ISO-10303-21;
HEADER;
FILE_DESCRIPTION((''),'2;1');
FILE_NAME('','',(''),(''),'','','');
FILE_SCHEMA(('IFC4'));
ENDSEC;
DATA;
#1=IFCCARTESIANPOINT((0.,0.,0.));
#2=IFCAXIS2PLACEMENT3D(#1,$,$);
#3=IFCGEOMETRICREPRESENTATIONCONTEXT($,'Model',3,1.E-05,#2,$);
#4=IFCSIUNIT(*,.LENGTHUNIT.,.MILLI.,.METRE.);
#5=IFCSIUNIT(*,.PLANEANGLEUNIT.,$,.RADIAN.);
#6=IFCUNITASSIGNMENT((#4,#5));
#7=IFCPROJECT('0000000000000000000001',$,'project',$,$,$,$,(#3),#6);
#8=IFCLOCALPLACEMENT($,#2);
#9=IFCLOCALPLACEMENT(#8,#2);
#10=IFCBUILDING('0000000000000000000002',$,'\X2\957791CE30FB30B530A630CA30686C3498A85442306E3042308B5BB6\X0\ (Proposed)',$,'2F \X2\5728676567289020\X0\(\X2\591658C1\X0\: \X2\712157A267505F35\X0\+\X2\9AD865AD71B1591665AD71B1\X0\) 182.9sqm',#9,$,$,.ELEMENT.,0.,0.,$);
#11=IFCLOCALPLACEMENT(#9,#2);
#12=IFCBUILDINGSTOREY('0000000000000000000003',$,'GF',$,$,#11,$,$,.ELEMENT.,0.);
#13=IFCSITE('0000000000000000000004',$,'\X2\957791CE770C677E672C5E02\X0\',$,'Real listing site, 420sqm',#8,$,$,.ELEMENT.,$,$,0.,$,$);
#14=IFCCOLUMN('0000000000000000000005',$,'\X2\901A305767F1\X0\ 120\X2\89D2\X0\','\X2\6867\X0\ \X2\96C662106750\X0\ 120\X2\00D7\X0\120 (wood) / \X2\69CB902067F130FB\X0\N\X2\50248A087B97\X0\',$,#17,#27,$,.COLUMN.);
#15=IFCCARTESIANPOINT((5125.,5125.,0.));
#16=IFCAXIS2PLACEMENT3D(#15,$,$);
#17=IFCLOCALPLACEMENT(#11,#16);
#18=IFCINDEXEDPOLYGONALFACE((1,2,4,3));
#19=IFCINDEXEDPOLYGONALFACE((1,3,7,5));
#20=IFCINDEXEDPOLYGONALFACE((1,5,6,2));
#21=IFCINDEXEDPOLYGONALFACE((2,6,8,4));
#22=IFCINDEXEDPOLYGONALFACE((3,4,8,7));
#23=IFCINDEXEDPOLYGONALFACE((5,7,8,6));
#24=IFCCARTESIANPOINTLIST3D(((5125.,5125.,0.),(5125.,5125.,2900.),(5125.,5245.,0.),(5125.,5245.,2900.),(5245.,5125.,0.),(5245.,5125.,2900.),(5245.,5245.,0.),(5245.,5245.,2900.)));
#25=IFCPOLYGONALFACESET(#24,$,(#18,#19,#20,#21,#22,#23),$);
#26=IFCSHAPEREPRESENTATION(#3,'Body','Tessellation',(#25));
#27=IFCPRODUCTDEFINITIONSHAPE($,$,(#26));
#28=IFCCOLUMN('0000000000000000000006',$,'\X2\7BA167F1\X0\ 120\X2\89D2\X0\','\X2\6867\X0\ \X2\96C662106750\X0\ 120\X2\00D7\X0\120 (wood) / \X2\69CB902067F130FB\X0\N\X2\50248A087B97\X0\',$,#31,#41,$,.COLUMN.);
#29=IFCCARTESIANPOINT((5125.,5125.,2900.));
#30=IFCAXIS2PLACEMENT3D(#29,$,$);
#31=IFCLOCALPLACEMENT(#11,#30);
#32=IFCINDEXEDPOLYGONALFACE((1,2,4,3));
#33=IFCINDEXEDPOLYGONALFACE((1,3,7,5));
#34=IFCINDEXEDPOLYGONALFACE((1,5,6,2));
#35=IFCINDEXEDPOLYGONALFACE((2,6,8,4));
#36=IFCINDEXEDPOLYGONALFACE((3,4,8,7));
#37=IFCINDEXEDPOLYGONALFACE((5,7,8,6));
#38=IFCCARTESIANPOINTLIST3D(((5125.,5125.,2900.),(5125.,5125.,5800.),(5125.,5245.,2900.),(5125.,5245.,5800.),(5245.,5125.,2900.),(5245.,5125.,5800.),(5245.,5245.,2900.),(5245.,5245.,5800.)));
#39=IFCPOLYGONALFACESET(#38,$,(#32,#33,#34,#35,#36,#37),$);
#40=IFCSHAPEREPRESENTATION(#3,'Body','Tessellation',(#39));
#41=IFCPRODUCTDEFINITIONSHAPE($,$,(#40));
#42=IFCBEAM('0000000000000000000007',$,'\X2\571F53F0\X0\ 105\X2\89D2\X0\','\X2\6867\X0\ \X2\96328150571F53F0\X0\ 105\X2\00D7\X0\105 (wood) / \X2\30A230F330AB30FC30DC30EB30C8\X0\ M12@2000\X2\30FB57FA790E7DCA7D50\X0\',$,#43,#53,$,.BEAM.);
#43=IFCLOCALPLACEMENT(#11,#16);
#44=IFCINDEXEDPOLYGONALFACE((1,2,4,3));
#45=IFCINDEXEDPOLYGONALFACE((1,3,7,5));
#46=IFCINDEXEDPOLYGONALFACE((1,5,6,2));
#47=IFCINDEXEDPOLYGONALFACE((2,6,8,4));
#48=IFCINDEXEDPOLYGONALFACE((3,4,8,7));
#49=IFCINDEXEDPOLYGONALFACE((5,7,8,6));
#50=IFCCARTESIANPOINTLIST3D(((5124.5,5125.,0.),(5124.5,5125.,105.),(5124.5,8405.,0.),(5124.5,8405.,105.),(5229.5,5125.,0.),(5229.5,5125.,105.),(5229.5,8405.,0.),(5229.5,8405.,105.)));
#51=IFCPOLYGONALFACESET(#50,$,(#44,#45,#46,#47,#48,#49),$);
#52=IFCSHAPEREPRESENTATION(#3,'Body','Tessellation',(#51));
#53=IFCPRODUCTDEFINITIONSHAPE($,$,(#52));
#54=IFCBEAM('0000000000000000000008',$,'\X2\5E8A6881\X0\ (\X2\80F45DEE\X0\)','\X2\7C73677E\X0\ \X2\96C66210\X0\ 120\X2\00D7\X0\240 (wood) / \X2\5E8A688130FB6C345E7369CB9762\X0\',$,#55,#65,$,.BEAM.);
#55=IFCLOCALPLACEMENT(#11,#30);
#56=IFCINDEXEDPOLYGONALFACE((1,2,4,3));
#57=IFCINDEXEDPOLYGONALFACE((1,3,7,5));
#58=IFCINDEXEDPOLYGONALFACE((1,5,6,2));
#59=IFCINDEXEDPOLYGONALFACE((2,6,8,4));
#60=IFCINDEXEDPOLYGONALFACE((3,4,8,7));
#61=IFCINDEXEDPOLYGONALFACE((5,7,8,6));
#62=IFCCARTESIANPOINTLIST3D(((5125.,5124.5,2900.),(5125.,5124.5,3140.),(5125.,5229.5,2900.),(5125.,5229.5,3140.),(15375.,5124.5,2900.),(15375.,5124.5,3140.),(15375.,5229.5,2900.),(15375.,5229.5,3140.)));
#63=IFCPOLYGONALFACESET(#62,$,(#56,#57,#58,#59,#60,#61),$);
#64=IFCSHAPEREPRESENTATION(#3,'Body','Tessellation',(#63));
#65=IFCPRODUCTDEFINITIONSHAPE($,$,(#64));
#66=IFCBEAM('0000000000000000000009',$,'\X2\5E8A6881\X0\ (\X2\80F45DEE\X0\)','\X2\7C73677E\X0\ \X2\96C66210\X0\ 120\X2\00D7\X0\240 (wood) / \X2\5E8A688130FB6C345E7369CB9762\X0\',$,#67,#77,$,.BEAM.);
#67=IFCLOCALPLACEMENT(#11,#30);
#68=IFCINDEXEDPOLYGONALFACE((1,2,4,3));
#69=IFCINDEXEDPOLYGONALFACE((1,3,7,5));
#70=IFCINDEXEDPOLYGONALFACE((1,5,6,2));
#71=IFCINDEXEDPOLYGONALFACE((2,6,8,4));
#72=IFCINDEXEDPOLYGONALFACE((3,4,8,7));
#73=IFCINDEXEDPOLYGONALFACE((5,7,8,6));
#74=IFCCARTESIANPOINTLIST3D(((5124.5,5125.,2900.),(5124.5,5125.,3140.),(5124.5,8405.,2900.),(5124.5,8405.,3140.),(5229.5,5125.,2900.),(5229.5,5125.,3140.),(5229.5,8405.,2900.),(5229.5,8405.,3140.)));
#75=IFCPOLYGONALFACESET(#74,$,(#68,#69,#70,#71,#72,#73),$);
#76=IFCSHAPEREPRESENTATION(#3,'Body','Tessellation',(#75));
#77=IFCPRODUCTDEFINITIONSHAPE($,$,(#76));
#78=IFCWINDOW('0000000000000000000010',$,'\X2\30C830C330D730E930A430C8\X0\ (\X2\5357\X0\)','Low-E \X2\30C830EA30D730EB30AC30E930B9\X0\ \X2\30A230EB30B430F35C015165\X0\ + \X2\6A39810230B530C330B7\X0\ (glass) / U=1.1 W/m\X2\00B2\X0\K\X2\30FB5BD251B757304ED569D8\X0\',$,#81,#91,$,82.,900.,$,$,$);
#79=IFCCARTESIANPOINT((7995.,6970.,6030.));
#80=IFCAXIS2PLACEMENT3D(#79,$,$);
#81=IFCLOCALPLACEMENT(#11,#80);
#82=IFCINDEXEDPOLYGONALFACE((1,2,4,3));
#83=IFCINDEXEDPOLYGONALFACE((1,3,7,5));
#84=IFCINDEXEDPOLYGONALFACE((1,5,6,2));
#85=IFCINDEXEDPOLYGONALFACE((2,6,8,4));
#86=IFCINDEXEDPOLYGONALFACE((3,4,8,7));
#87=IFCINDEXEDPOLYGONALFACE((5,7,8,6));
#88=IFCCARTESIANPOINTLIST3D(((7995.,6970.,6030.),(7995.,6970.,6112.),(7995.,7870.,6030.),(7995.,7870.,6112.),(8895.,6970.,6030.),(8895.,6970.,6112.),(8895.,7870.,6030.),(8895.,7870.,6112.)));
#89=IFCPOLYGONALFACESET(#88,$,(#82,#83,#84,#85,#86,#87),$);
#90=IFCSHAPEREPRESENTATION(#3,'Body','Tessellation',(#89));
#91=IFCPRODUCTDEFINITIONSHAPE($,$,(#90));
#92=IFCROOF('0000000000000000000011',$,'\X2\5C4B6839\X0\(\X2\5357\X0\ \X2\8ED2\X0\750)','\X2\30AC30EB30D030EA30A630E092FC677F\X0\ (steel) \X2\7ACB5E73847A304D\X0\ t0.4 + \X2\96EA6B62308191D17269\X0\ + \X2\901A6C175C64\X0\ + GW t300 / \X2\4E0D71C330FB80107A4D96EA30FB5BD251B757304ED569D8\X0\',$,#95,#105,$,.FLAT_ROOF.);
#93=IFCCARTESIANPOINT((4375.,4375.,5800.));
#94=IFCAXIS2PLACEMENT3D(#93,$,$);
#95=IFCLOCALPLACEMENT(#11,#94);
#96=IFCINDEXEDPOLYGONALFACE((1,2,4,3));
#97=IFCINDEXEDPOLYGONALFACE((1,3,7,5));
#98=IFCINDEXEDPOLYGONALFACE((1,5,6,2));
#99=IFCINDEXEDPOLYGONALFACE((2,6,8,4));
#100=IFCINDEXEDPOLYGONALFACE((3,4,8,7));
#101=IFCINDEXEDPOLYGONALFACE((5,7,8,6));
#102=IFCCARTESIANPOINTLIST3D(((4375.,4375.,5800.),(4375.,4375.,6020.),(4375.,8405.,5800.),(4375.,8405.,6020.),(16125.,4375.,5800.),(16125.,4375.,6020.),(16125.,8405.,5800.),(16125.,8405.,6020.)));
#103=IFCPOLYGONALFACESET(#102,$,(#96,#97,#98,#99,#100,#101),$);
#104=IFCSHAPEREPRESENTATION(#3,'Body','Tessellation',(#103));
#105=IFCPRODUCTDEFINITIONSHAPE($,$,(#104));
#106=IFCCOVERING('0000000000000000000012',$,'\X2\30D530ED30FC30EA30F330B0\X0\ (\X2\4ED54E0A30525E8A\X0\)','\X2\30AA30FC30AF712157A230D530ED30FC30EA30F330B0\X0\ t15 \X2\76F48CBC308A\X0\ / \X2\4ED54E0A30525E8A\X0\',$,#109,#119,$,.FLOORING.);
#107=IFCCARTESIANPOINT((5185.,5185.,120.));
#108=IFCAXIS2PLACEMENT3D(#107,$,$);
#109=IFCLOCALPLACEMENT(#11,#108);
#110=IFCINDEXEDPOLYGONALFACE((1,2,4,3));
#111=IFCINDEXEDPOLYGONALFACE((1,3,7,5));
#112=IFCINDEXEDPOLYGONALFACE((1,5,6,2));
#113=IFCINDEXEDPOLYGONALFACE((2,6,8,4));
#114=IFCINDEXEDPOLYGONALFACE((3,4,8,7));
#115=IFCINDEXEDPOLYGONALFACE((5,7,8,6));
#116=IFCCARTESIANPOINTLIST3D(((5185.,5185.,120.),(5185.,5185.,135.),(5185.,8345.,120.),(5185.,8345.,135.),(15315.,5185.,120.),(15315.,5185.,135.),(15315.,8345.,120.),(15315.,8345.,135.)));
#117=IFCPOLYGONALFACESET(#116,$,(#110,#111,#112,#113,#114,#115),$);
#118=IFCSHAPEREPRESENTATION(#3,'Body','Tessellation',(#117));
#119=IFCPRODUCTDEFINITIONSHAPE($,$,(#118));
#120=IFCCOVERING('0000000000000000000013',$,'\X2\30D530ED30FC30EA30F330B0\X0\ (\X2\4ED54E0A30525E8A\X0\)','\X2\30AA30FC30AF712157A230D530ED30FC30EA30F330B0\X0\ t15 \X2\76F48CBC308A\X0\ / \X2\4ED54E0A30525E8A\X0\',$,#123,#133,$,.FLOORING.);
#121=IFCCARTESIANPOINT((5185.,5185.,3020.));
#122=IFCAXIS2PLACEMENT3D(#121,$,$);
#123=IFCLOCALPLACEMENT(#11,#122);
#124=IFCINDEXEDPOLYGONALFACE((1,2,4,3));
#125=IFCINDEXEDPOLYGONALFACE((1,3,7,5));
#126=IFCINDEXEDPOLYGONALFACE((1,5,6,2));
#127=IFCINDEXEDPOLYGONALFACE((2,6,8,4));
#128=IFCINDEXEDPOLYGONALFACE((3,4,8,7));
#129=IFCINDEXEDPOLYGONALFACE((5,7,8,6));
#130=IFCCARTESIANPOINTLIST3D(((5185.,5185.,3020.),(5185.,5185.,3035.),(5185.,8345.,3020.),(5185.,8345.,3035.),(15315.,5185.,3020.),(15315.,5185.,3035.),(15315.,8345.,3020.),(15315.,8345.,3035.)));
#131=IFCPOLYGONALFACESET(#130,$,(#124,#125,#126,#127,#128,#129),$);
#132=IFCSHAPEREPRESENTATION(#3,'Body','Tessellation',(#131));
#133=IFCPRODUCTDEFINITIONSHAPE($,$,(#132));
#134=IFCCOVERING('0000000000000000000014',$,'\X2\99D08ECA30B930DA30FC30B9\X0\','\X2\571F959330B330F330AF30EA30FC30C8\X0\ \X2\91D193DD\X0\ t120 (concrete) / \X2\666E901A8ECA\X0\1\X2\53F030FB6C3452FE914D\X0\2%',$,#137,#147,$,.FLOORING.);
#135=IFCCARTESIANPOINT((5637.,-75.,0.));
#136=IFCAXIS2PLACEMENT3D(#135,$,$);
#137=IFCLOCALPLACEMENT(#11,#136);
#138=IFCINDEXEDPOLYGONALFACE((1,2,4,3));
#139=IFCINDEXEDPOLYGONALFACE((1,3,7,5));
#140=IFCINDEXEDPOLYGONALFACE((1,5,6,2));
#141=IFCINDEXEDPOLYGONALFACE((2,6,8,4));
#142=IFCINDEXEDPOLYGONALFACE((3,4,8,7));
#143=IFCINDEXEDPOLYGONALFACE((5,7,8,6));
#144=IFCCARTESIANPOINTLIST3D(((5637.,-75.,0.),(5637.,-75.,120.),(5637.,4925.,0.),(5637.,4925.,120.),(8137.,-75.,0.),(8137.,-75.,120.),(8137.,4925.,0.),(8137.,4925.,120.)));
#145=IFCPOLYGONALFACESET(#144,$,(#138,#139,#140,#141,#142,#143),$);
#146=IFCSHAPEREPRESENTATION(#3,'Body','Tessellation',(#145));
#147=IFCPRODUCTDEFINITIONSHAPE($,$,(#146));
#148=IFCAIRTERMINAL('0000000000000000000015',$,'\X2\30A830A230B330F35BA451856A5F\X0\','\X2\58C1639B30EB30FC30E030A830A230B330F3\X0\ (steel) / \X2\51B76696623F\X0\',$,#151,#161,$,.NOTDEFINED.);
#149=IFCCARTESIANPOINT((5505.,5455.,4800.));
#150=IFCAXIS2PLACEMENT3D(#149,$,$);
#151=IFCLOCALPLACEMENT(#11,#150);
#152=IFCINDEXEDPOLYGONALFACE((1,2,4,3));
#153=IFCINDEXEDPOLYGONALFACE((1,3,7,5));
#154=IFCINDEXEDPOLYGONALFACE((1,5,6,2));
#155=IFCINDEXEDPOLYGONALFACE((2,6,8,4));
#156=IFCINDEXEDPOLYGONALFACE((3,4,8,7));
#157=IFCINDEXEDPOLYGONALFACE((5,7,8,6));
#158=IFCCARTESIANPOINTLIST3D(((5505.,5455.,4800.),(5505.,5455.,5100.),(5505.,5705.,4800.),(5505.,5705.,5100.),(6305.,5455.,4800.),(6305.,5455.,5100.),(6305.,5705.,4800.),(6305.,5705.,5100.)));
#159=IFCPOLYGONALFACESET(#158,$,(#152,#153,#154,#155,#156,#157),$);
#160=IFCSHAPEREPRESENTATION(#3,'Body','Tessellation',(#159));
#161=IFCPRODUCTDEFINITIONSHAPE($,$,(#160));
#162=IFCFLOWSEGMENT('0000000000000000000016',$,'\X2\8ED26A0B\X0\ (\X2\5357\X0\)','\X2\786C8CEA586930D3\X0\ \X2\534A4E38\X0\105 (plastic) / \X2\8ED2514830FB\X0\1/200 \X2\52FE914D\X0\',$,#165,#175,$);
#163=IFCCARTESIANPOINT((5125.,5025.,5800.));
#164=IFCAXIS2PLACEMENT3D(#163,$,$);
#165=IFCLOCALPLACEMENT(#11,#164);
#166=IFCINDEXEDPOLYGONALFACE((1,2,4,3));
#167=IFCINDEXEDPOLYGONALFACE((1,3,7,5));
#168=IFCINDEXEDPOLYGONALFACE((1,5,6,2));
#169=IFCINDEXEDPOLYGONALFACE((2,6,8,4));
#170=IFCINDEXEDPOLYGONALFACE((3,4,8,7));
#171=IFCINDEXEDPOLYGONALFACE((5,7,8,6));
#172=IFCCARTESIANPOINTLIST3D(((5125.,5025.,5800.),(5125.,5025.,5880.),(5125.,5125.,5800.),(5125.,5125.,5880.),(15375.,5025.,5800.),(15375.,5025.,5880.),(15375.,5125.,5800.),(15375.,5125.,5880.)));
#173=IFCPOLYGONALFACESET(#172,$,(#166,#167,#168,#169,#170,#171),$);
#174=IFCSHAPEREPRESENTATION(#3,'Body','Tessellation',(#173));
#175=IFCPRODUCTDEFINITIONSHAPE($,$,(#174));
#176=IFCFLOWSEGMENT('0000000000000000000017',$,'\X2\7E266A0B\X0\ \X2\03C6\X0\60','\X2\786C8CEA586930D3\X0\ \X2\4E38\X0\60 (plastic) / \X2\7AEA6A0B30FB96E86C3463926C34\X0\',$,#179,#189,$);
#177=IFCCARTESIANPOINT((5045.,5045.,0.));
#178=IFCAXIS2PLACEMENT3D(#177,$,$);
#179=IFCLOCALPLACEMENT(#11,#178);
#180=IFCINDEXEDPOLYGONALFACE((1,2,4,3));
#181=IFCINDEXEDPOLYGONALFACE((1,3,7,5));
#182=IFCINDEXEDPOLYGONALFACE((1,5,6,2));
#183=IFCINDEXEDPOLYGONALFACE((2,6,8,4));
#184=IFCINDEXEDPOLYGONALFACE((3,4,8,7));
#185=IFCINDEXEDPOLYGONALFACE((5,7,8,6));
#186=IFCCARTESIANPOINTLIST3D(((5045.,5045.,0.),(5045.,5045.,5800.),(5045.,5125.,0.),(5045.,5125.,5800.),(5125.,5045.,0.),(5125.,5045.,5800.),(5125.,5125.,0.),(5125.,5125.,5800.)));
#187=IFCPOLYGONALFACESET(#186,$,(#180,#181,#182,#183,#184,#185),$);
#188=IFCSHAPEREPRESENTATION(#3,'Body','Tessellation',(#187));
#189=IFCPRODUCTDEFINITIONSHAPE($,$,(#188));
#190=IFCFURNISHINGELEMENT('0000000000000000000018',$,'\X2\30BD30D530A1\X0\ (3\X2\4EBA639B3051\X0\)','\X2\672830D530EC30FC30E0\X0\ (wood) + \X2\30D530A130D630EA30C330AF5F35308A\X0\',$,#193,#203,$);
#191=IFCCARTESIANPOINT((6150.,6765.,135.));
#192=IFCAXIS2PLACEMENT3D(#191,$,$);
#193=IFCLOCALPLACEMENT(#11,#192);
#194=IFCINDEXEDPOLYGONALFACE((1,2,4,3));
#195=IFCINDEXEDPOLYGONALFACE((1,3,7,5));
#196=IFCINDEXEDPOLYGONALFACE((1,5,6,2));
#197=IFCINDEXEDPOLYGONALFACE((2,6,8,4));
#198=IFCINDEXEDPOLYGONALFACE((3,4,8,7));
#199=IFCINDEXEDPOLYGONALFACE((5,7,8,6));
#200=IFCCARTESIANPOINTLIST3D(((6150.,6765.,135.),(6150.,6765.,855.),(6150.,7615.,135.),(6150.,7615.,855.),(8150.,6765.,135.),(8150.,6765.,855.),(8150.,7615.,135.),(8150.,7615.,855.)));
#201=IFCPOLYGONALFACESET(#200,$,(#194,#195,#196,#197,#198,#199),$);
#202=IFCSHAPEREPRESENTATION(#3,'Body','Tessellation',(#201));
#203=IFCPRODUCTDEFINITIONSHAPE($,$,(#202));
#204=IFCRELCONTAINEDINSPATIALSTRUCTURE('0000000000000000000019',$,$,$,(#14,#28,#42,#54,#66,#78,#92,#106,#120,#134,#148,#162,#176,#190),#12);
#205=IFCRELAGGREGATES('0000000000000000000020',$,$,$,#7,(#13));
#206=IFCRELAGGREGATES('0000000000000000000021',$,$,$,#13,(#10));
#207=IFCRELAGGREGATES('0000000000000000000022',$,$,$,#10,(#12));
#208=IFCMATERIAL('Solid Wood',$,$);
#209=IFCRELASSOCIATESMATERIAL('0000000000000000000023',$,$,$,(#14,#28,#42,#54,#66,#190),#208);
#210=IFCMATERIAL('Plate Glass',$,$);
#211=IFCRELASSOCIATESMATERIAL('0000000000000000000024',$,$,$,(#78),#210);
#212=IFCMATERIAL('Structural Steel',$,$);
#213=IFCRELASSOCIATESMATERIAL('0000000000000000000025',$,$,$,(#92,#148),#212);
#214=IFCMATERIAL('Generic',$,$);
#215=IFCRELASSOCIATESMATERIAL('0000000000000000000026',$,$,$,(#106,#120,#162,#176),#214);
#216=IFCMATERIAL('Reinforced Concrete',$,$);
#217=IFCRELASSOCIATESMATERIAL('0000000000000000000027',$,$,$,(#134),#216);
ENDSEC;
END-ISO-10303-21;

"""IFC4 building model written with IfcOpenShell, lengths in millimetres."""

from ifc_helpers import new_model, si_unit, frame, frame_2d, origin, place, context, project, spatial, rectangle, extrude, material, element, save


model = new_model("IFC4")

# Units and contexts
model_context = context("Model", 3, precision=1e-05, world=origin())
ifc_project = project(units=[si_unit("LENGTHUNIT", "METRE", prefix="MILLI"), si_unit("PLANEANGLEUNIT", "RADIAN")], contexts=[model_context])

# Site, building, storey
site_placement = place(None, origin())
site = spatial("IfcSite", under=ifc_project, at=site_placement, Name="長野県松本市", ObjectType="Real listing site, 420sqm", CompositionType="ELEMENT", RefElevation=0.0)
building_placement = place(site_placement, origin())
building = spatial("IfcBuilding", under=site, at=building_placement, Name="長野・サウナと水風呂のある家 (Proposed)", ObjectType="2F 在来木造(外壁: 無垢材張+高断熱外断熱) 182.9sqm", CompositionType="ELEMENT", ElevationOfRefHeight=0.0, ElevationOfTerrain=0.0)
storey_placement = place(building_placement, origin())
storey = spatial("IfcBuildingStorey", under=building, at=storey_placement, Name="GF", CompositionType="ELEMENT", Elevation=0.0)

# Columns
ifc_material_1 = material(Name="Solid Wood")
column_1_placement = place(storey_placement, frame((5125.0, 5125.0, 0.0)))
element("IfcColumn", 1, at=column_1_placement, inside=storey, material=ifc_material_1, Name="通し柱 120角", Description="桧 集成材 120×120 (wood) / 構造柱・N値計算", PredefinedType="COLUMN", context=model_context, shape_type="SweptSolid", body=[
    extrude(rectangle(XDim=120.0, YDim=120.0, at=frame_2d((60.0, 60.0))), frame((5125.0, 5125.0, 0.0)), (0.0, 0.0, 1.0), 2900.0),
])
column_2_placement = place(storey_placement, frame((5125.0, 5125.0, 2900.0)))
element("IfcColumn", 2, at=column_2_placement, inside=storey, material=ifc_material_1, Name="管柱 120角", Description="桧 集成材 120×120 (wood) / 構造柱・N値計算", PredefinedType="COLUMN", context=model_context, shape_type="SweptSolid", body=[
    extrude(rectangle(XDim=120.0, YDim=120.0, at=frame_2d((60.0, 60.0))), frame((5125.0, 5125.0, 2900.0)), (0.0, 0.0, 1.0), 2900.0),
])

# Beams
beam_1_placement = place(storey_placement, frame((5125.0, 5125.0, 0.0)))
element("IfcBeam", 3, at=beam_1_placement, inside=storey, material=ifc_material_1, Name="土台 105角", Description="桧 防腐土台 105×105 (wood) / アンカーボルト M12@2000・基礎緊結", PredefinedType="BEAM", context=model_context, shape_type="SweptSolid", body=[
    extrude(rectangle(XDim=105.0, YDim=3280.0, at=frame_2d((52.0, 1640.0))), frame((5125.0, 5125.0, 0.0)), (0.0, 0.0, 1.0), 105.0),
])
beam_2_placement = place(storey_placement, frame((5125.0, 5125.0, 2900.0)))
element("IfcBeam", 4, at=beam_2_placement, inside=storey, material=ifc_material_1, Name="床梁 (胴差)", Description="米松 集成 120×240 (wood) / 床梁・水平構面", PredefinedType="BEAM", context=model_context, shape_type="SweptSolid", body=[
    extrude(rectangle(XDim=10250.0, YDim=105.0, at=frame_2d((5125.0, 52.0))), frame((5125.0, 5125.0, 2900.0)), (0.0, 0.0, 1.0), 240.0),
])
beam_3_placement = place(storey_placement, frame((5125.0, 5125.0, 2900.0)))
element("IfcBeam", 5, at=beam_3_placement, inside=storey, material=ifc_material_1, Name="床梁 (胴差)", Description="米松 集成 120×240 (wood) / 床梁・水平構面", PredefinedType="BEAM", context=model_context, shape_type="SweptSolid", body=[
    extrude(rectangle(XDim=105.0, YDim=3280.0, at=frame_2d((52.0, 1640.0))), frame((5125.0, 5125.0, 2900.0)), (0.0, 0.0, 1.0), 240.0),
])

# Shared definitions
ifc_material_2 = material(Name="Reinforced Concrete")

# Shared definitions
ifc_material_3 = material(Name="Plate Glass")

# Window
window_1_placement = place(storey_placement, frame((7995.0, 6970.0, 6030.0)))
element("IfcWindow", 6, at=window_1_placement, inside=storey, material=ifc_material_3, Name="トップライト (南)", Description="Low-E トリプルガラス アルゴン封入 + 樹脂サッシ (glass) / U=1.1 W/m²K・寒冷地仕様", OverallHeight=82.0, OverallWidth=900.0, context=model_context, shape_type="SweptSolid", body=[
    extrude(rectangle(XDim=900.0, YDim=900.0, at=frame_2d((450.0, 450.0))), frame((7995.0, 6970.0, 6030.0)), (0.0, 0.0, 1.0), 82.0),
])

# Roof
ifc_material_4 = material(Name="Structural Steel")
for number, where, name in (
    (7, (4375.0, 4375.0, 5800.0), "屋根(南 軒750)"),
):
    element("IfcRoof", number, at=place(storey_placement, frame(where)), inside=storey, material=ifc_material_4, Name=name, Description="ガルバリウム鋼板 (steel) 立平葺き t0.4 + 雪止め金物 + 通気層 + GW t300 / 不燃・耐積雪・寒冷地仕様", PredefinedType="FLAT_ROOF", context=model_context, shape_type="SweptSolid", body=[
        extrude(rectangle(XDim=11750.0, YDim=4030.0, at=frame_2d((5875.0, 2015.0))), frame((4375.0, 4375.0, 5800.0)), (0.0, 0.0, 1.0), 220.0),
    ])

# Coverings
ifc_material_5 = material(Name="Generic")
covering_1_placement = place(storey_placement, frame((5185.0, 5185.0, 120.0)))
element("IfcCovering", 8, at=covering_1_placement, inside=storey, material=ifc_material_5, Name="フローリング (仕上げ床)", Description="オーク無垢フローリング t15 直貼り / 仕上げ床", PredefinedType="FLOORING", context=model_context, shape_type="SweptSolid", body=[
    extrude(rectangle(XDim=10130.0, YDim=3160.0, at=frame_2d((5065.0, 1580.0))), frame((5185.0, 5185.0, 120.0)), (0.0, 0.0, 1.0), 15.0),
])
covering_2_placement = place(storey_placement, frame((5185.0, 5185.0, 3020.0)))
element("IfcCovering", 9, at=covering_2_placement, inside=storey, material=ifc_material_5, Name="フローリング (仕上げ床)", Description="オーク無垢フローリング t15 直貼り / 仕上げ床", PredefinedType="FLOORING", context=model_context, shape_type="SweptSolid", body=[
    extrude(rectangle(XDim=10130.0, YDim=3160.0, at=frame_2d((5065.0, 1580.0))), frame((5185.0, 5185.0, 3020.0)), (0.0, 0.0, 1.0), 15.0),
])
covering_3_placement = place(storey_placement, frame((5637.0, -75.0, 0.0)))
element("IfcCovering", 10, at=covering_3_placement, inside=storey, material=ifc_material_2, Name="駐車スペース", Description="土間コンクリート 金鏝 t120 (concrete) / 普通車1台・水勾配2%", PredefinedType="FLOORING", context=model_context, shape_type="SweptSolid", body=[
    extrude(rectangle(XDim=2500.0, YDim=5000.0, at=frame_2d((1250.0, 2500.0))), frame((5637.0, -75.0, 0.0)), (0.0, 0.0, 1.0), 120.0),
])

# Air terminal
air_terminal_placement = place(storey_placement, frame((5505.0, 5455.0, 4800.0)))
element("IfcAirTerminal", 11, at=air_terminal_placement, inside=storey, material=ifc_material_4, Name="エアコン室内機", Description="壁掛ルームエアコン (steel) / 冷暖房", PredefinedType="NOTDEFINED", context=model_context, shape_type="SweptSolid", body=[
    extrude(rectangle(XDim=800.0, YDim=250.0, at=frame_2d((400.0, 125.0))), frame((5505.0, 5455.0, 4800.0)), (0.0, 0.0, 1.0), 300.0),
])

# Flow segments
flow_segment_1_placement = place(storey_placement, frame((5125.0, 5025.0, 5800.0)))
element("IfcFlowSegment", 12, at=flow_segment_1_placement, inside=storey, material=ifc_material_5, Name="軒樋 (南)", Description="硬質塩ビ 半丸105 (plastic) / 軒先・1/200 勾配", context=model_context, shape_type="SweptSolid", body=[
    extrude(rectangle(XDim=10250.0, YDim=100.0, at=frame_2d((5125.0, 50.0))), frame((5125.0, 5025.0, 5800.0)), (0.0, 0.0, 1.0), 80.0),
])
flow_segment_2_placement = place(storey_placement, frame((5045.0, 5045.0, 0.0)))
element("IfcFlowSegment", 13, at=flow_segment_2_placement, inside=storey, material=ifc_material_5, Name="縦樋 φ60", Description="硬質塩ビ 丸60 (plastic) / 竪樋・雨水排水", context=model_context, shape_type="SweptSolid", body=[
    extrude(rectangle(XDim=80.0, YDim=80.0, at=frame_2d((40.0, 40.0))), frame((5045.0, 5045.0, 0.0)), (0.0, 0.0, 1.0), 5800.0),
])

# Furnishing element
furnishing_1_placement = place(storey_placement, frame((6150.0, 6765.0, 135.0)))
element("IfcFurnishingElement", 14, at=furnishing_1_placement, inside=storey, material=ifc_material_1, Name="ソファ (3人掛け)", Description="木フレーム (wood) + ファブリック張り", context=model_context, shape_type="SweptSolid", body=[
    extrude(rectangle(XDim=2000.0, YDim=850.0, at=frame_2d((1000.0, 425.0))), frame((6150.0, 6765.0, 135.0)), (0.0, 0.0, 1.0), 720.0),
])

save(model, "model.ifc")
